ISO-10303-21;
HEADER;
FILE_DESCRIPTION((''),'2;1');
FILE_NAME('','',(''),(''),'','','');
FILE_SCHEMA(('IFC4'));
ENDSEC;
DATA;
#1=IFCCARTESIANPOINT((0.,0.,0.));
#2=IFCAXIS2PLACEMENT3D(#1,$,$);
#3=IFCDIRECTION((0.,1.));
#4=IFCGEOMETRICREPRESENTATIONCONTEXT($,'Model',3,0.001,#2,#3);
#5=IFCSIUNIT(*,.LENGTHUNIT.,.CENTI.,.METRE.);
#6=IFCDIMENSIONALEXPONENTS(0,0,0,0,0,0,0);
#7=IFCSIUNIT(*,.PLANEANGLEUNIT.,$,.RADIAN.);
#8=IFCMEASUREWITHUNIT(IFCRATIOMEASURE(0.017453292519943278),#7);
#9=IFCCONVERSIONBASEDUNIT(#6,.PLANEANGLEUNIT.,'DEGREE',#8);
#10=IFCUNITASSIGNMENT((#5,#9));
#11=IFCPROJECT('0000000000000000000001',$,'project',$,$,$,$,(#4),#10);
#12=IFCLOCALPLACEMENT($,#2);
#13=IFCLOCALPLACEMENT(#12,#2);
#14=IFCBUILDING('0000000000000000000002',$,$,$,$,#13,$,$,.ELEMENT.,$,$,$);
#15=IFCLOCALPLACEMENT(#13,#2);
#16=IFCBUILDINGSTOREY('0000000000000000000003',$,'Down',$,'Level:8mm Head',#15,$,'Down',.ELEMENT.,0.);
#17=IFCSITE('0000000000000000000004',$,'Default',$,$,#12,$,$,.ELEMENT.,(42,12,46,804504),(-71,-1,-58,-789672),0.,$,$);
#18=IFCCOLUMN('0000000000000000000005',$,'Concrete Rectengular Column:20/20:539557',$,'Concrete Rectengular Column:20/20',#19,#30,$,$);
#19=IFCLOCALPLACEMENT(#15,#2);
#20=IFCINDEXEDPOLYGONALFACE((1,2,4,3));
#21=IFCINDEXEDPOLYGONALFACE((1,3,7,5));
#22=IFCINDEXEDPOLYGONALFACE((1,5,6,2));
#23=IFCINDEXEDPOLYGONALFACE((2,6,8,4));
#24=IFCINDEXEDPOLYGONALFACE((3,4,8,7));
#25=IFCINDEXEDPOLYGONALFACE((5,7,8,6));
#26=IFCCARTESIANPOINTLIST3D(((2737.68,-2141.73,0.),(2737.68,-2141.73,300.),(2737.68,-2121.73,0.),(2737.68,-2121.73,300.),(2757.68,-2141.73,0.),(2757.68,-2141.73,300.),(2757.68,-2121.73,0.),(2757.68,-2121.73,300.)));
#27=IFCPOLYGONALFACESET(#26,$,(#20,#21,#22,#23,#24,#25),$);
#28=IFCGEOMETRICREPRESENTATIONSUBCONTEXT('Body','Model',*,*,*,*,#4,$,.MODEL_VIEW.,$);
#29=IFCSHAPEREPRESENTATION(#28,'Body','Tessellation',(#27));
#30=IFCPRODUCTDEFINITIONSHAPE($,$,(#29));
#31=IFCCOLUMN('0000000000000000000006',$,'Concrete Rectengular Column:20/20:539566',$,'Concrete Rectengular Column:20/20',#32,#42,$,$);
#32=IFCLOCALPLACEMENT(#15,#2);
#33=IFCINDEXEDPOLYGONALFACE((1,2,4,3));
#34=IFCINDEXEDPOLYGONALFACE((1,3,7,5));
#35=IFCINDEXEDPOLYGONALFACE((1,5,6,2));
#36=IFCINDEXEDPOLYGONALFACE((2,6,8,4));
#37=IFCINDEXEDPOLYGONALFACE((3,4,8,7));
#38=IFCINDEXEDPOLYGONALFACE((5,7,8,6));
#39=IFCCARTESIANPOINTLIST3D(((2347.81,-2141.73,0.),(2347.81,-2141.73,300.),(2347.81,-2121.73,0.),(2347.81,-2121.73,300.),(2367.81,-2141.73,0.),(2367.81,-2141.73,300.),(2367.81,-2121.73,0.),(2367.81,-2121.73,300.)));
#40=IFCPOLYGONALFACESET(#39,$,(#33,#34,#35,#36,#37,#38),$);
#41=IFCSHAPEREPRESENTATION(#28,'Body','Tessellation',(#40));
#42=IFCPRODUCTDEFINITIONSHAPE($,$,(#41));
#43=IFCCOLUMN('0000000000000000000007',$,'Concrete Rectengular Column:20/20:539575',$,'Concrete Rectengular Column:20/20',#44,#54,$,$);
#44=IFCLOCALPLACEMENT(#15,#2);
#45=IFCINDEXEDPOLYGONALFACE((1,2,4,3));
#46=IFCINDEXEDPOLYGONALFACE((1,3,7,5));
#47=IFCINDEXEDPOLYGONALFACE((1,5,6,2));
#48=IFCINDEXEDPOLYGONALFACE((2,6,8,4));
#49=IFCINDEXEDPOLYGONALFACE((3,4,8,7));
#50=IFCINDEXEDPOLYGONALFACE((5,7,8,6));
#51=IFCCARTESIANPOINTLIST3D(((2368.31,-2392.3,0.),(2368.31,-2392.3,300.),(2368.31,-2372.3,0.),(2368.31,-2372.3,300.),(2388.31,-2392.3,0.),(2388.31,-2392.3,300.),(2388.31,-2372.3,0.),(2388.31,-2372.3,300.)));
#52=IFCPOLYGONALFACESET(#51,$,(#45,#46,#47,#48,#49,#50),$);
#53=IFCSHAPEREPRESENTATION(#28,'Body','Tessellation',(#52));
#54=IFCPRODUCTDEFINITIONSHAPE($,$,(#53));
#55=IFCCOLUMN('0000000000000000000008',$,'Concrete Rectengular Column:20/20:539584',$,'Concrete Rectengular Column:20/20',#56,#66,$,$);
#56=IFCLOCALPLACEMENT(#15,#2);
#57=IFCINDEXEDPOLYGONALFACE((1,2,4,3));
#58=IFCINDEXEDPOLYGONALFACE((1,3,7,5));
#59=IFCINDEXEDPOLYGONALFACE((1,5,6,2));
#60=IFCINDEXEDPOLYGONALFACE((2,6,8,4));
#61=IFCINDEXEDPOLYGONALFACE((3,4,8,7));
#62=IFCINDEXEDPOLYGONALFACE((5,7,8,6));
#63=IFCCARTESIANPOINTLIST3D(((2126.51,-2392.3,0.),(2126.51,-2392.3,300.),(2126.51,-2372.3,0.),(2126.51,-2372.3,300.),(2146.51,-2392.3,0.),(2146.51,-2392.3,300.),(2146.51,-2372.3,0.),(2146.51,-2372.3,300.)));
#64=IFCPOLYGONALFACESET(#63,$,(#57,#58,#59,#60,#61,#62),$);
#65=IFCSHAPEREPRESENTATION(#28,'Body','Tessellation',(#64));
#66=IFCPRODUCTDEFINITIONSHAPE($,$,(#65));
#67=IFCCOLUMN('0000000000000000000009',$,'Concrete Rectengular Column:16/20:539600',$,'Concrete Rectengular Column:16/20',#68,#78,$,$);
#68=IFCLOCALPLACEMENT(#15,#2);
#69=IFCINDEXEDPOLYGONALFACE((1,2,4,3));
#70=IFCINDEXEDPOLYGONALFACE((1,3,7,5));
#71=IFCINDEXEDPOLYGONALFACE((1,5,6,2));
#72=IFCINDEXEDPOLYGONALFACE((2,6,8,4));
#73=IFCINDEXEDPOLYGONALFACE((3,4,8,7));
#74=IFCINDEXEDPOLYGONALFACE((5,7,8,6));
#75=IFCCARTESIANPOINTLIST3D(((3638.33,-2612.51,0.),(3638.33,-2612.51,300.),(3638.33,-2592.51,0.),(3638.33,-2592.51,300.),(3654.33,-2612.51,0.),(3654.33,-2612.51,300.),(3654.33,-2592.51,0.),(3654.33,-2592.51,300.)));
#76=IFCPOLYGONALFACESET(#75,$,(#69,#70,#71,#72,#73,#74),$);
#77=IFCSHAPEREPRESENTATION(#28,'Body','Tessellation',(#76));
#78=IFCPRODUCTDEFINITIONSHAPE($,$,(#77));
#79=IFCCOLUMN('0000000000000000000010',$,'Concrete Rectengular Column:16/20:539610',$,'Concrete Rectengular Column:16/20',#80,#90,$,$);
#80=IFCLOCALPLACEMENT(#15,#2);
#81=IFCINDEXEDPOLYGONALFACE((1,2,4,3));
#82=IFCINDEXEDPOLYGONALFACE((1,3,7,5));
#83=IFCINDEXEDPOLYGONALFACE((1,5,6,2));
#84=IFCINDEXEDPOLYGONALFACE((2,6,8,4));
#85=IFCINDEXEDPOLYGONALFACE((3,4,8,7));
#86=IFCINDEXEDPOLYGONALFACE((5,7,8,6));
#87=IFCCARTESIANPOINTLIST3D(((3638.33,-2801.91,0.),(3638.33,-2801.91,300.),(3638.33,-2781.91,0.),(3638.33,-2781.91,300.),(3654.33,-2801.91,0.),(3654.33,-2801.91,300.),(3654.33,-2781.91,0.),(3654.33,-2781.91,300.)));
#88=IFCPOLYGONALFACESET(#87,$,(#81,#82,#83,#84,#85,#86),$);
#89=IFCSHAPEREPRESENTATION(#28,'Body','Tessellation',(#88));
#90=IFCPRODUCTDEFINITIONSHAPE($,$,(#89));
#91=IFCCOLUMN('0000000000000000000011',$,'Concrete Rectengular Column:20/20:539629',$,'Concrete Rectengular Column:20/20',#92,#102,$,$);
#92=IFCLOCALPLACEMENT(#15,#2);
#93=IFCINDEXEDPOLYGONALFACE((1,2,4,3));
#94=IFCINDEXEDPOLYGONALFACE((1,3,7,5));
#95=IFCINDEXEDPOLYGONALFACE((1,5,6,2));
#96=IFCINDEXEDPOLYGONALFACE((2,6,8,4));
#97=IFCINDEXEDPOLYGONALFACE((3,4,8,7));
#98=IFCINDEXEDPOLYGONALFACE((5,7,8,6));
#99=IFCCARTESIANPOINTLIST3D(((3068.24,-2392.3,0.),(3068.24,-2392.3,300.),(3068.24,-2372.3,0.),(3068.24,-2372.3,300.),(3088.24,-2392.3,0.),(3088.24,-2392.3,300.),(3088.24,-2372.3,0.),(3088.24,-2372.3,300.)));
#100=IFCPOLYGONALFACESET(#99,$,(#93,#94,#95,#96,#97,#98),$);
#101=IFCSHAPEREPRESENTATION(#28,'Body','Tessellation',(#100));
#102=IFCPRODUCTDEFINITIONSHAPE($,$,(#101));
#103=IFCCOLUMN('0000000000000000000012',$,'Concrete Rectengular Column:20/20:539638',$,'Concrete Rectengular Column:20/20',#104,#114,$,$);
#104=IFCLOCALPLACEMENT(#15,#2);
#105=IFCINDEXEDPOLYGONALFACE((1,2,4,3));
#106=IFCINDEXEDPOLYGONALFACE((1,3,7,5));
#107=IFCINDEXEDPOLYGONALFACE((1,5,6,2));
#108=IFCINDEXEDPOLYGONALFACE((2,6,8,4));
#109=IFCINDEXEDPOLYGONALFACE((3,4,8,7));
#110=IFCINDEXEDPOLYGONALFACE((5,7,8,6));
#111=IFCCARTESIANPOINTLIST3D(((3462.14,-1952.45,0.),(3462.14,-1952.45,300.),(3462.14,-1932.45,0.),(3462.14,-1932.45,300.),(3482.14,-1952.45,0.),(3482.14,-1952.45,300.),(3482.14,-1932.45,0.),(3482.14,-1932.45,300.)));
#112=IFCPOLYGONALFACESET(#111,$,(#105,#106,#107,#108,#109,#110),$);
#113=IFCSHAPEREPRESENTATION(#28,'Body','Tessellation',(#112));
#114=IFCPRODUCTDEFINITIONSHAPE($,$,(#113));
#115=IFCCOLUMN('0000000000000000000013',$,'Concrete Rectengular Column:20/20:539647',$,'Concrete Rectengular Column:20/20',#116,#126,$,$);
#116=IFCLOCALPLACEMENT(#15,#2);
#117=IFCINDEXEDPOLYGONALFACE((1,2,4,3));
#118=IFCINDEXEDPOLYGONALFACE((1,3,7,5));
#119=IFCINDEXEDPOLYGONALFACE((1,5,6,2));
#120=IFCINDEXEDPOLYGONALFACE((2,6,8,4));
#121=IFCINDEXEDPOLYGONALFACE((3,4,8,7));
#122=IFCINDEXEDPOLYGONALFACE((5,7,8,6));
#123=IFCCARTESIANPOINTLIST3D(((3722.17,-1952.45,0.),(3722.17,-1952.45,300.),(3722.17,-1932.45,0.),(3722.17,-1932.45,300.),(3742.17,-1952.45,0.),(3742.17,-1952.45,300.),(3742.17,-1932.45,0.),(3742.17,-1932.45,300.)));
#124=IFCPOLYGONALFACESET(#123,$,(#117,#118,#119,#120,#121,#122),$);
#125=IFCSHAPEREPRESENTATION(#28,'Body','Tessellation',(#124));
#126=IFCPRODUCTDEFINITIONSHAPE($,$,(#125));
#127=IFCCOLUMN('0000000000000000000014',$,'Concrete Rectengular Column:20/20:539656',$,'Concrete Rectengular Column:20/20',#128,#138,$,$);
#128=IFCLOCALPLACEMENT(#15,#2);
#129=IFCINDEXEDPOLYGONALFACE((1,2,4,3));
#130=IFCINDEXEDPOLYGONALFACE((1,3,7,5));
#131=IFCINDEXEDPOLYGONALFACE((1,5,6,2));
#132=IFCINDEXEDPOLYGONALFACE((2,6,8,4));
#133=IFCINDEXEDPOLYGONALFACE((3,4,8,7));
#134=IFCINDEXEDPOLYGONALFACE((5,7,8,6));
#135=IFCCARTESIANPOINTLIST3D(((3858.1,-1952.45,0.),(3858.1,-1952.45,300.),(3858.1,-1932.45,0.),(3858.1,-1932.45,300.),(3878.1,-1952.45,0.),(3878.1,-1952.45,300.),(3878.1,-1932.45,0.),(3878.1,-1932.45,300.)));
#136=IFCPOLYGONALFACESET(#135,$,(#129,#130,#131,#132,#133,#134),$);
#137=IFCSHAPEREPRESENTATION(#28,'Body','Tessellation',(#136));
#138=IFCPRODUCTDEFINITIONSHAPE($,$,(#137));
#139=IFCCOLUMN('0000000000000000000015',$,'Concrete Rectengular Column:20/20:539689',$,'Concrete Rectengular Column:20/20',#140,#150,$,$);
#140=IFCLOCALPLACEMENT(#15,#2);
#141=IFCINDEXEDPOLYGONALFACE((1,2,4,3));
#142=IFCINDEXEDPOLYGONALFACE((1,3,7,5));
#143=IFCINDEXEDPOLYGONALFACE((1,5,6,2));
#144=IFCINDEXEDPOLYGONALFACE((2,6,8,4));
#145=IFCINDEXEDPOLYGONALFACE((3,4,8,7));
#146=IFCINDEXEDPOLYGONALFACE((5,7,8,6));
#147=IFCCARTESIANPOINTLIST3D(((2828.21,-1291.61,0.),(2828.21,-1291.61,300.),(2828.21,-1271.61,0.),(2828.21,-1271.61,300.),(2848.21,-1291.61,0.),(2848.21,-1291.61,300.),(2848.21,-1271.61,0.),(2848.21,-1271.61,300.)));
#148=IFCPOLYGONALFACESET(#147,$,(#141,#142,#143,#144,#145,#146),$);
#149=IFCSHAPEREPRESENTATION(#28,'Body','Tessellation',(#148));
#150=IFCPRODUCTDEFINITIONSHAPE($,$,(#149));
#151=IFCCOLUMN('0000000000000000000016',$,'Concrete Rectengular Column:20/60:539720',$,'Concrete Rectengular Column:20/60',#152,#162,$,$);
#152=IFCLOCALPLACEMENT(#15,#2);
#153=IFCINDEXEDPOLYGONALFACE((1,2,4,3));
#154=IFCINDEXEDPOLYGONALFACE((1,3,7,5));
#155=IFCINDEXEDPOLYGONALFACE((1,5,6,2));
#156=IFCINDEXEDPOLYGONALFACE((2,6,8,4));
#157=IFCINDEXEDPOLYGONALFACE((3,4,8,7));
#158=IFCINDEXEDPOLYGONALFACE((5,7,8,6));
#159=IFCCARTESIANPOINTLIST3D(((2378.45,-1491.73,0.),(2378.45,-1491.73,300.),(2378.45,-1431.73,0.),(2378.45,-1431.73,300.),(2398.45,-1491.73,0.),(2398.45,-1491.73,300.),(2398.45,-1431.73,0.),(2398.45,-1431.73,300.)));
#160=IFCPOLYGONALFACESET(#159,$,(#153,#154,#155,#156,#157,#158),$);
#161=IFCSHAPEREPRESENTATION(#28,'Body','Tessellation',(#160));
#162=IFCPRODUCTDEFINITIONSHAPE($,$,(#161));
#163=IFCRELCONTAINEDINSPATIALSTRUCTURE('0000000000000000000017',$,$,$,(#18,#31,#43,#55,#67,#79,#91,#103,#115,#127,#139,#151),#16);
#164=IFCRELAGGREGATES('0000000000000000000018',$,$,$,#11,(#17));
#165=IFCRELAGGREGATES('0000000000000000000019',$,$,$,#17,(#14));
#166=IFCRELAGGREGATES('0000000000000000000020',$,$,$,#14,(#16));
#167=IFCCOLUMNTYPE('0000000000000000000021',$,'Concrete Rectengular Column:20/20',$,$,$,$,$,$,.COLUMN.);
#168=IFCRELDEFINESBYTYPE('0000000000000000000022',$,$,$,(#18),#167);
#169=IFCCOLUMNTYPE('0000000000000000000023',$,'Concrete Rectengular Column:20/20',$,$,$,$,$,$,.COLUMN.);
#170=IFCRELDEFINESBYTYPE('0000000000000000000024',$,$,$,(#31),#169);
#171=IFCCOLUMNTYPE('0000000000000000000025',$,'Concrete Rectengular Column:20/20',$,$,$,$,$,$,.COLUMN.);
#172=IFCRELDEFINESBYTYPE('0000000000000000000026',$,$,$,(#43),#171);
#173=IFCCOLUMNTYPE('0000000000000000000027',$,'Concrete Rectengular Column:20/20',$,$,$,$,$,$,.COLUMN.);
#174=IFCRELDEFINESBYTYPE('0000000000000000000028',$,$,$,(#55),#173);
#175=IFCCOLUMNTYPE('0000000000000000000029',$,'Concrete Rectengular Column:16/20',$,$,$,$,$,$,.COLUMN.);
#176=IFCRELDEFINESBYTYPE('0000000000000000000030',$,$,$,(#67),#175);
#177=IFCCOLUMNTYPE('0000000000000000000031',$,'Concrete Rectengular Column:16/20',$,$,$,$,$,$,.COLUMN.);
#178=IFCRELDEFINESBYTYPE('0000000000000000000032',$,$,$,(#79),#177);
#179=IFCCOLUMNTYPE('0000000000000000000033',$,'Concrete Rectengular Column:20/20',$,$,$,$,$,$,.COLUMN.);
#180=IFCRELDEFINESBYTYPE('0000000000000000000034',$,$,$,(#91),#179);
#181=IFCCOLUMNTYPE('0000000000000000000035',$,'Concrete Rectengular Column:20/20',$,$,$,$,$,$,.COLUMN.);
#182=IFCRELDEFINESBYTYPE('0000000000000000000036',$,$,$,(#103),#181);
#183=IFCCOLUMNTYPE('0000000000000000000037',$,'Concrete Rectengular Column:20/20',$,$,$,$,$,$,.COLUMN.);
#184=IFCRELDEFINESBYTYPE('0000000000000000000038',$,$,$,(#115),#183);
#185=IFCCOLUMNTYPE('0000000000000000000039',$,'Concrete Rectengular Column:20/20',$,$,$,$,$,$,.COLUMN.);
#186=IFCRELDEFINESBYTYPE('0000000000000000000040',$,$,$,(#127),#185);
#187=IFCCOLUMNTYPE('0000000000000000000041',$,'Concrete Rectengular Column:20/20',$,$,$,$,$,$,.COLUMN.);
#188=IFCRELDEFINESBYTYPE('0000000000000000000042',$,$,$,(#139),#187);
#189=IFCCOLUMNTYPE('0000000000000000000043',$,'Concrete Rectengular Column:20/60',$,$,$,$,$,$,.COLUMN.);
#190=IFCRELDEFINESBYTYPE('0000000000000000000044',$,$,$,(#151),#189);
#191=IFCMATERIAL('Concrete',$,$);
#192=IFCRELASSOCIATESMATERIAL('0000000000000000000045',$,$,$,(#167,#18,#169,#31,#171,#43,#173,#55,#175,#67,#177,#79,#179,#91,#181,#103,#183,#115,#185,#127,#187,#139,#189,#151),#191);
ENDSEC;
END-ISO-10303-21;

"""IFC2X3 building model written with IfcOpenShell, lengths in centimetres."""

from ifc_helpers import new_model, entity, si_unit, converted_unit, direction, frame, frame_2d, origin, origin_2d_with_axis, place, context, subcontext, project, spatial, rectangle, extrude, source, transform, mapped, material, type_object, type_shapes, element, save


model = new_model("IFC2X3")

# Units and contexts
model_context = context("Model", 3, precision=0.001, world=origin(), true_north=direction((0.0, 1.0)))
body_context = subcontext(model_context, "Body", "Model", "MODEL_VIEW")
ifc_project = project(units=[si_unit("LENGTHUNIT", "METRE", prefix="CENTI"), converted_unit("PLANEANGLEUNIT", "DEGREE", entity("IfcRatioMeasure", 0.017453292519943278), si_unit("PLANEANGLEUNIT", "RADIAN"), dimensions=[0, 0, 0, 0, 0, 0, 0])], contexts=[model_context])

# Site, building, storey
site_placement = place(None, origin())
site = spatial("IfcSite", under=ifc_project, at=site_placement, Name="Default", CompositionType="ELEMENT", RefLatitude=(42, 12, 46, 804504), RefLongitude=(-71, -1, -58, -789672), RefElevation=0.0)
building_placement = place(site_placement, origin())
building = spatial("IfcBuilding", under=site, at=building_placement, CompositionType="ELEMENT")
storey_placement = place(building_placement, origin())
storey = spatial("IfcBuildingStorey", under=building, at=storey_placement, Name="Down", ObjectType="Level:8mm Head", LongName="Down", CompositionType="ELEMENT", Elevation=0.0)

# Columns
ifc_material = material(Name="Concrete")
column_type_1 = type_object("IfcColumnType", Name="Concrete Rectengular Column:20/20", PredefinedType="COLUMN", material=ifc_material)
shared_shape_1 = source(origin(), body_context, "Body", "SweptSolid", [
    extrude(rectangle(XDim=20.0, YDim=20.0, at=origin_2d_with_axis()), frame((2747.68, -2131.73, 0.0), z_axis=(0.0, 0.0, 1.0), x_axis=(0.0, -1.0, 0.0)), (0.0, 0.0, 1.0), 300.0),
])
type_shapes(column_type_1, [shared_shape_1])
column_1_placement = place(storey_placement, origin())
element("IfcColumn", 1, at=column_1_placement, inside=storey, type_object=column_type_1, material=ifc_material, Name="Concrete Rectengular Column:20/20:539557", ObjectType="Concrete Rectengular Column:20/20", context=body_context, shape_type="MappedRepresentation", body=[
    mapped(shared_shape_1, transform((0.0, 0.0, 0.0), scale=1.0)),
])
column_type_2 = type_object("IfcColumnType", Name="Concrete Rectengular Column:20/20", PredefinedType="COLUMN", material=ifc_material)
shared_shape_2 = source(origin(), body_context, "Body", "SweptSolid", [
    extrude(rectangle(XDim=20.0, YDim=20.0, at=origin_2d_with_axis()), frame((2357.81, -2131.73, 0.0), z_axis=(0.0, 0.0, 1.0), x_axis=(0.0, -1.0, 0.0)), (0.0, 0.0, 1.0), 300.0),
])
type_shapes(column_type_2, [shared_shape_2])
column_2_placement = place(storey_placement, origin())
element("IfcColumn", 2, at=column_2_placement, inside=storey, type_object=column_type_2, material=ifc_material, Name="Concrete Rectengular Column:20/20:539566", ObjectType="Concrete Rectengular Column:20/20", context=body_context, shape_type="MappedRepresentation", body=[
    mapped(shared_shape_2, transform((0.0, 0.0, 0.0), scale=1.0)),
])
column_type_3 = type_object("IfcColumnType", Name="Concrete Rectengular Column:20/20", PredefinedType="COLUMN", material=ifc_material)
shared_shape_3 = source(origin(), body_context, "Body", "SweptSolid", [
    extrude(rectangle(XDim=20.0, YDim=20.0, at=origin_2d_with_axis()), frame((2378.31, -2382.3, 0.0), z_axis=(0.0, 0.0, 1.0), x_axis=(0.0, -1.0, 0.0)), (0.0, 0.0, 1.0), 300.0),
])
type_shapes(column_type_3, [shared_shape_3])
column_3_placement = place(storey_placement, origin())
element("IfcColumn", 3, at=column_3_placement, inside=storey, type_object=column_type_3, material=ifc_material, Name="Concrete Rectengular Column:20/20:539575", ObjectType="Concrete Rectengular Column:20/20", context=body_context, shape_type="MappedRepresentation", body=[
    mapped(shared_shape_3, transform((0.0, 0.0, 0.0), scale=1.0)),
])
column_type_4 = type_object("IfcColumnType", Name="Concrete Rectengular Column:20/20", PredefinedType="COLUMN", material=ifc_material)
shared_shape_4 = source(origin(), body_context, "Body", "SweptSolid", [
    extrude(rectangle(XDim=20.0, YDim=20.0, at=origin_2d_with_axis()), frame((2136.51, -2382.3, 0.0), z_axis=(0.0, 0.0, 1.0), x_axis=(0.0, -1.0, 0.0)), (0.0, 0.0, 1.0), 300.0),
])
type_shapes(column_type_4, [shared_shape_4])
column_4_placement = place(storey_placement, origin())
element("IfcColumn", 4, at=column_4_placement, inside=storey, type_object=column_type_4, material=ifc_material, Name="Concrete Rectengular Column:20/20:539584", ObjectType="Concrete Rectengular Column:20/20", context=body_context, shape_type="MappedRepresentation", body=[
    mapped(shared_shape_4, transform((0.0, 0.0, 0.0), scale=1.0)),
])
column_type_5 = type_object("IfcColumnType", Name="Concrete Rectengular Column:16/20", PredefinedType="COLUMN", material=ifc_material)
shared_shape_5 = source(origin(), body_context, "Body", "SweptSolid", [
    extrude(rectangle(XDim=20.0, YDim=16.0, at=origin_2d_with_axis()), frame((3646.33, -2602.51, 0.0), z_axis=(0.0, 0.0, 1.0), x_axis=(0.0, -1.0, 0.0)), (0.0, 0.0, 1.0), 300.0),
])
type_shapes(column_type_5, [shared_shape_5])
column_5_placement = place(storey_placement, origin())
element("IfcColumn", 5, at=column_5_placement, inside=storey, type_object=column_type_5, material=ifc_material, Name="Concrete Rectengular Column:16/20:539600", ObjectType="Concrete Rectengular Column:16/20", context=body_context, shape_type="MappedRepresentation", body=[
    mapped(shared_shape_5, transform((0.0, 0.0, 0.0), scale=1.0)),
])
column_type_6 = type_object("IfcColumnType", Name="Concrete Rectengular Column:16/20", PredefinedType="COLUMN", material=ifc_material)
shared_shape_6 = source(origin(), body_context, "Body", "SweptSolid", [
    extrude(rectangle(XDim=20.0, YDim=16.0, at=origin_2d_with_axis()), frame((3646.33, -2791.91, 0.0), z_axis=(0.0, 0.0, 1.0), x_axis=(0.0, -1.0, 0.0)), (0.0, 0.0, 1.0), 300.0),
])
type_shapes(column_type_6, [shared_shape_6])
column_6_placement = place(storey_placement, origin())
element("IfcColumn", 6, at=column_6_placement, inside=storey, type_object=column_type_6, material=ifc_material, Name="Concrete Rectengular Column:16/20:539610", ObjectType="Concrete Rectengular Column:16/20", context=body_context, shape_type="MappedRepresentation", body=[
    mapped(shared_shape_6, transform((0.0, 0.0, 0.0), scale=1.0)),
])
column_type_7 = type_object("IfcColumnType", Name="Concrete Rectengular Column:20/20", PredefinedType="COLUMN", material=ifc_material)
shared_shape_7 = source(origin(), body_context, "Body", "SweptSolid", [
    extrude(rectangle(XDim=20.0, YDim=20.0, at=origin_2d_with_axis()), frame((3078.24, -2382.3, 0.0), z_axis=(0.0, 0.0, 1.0), x_axis=(0.0, -1.0, 0.0)), (0.0, 0.0, 1.0), 300.0),
])
type_shapes(column_type_7, [shared_shape_7])
column_7_placement = place(storey_placement, origin())
element("IfcColumn", 7, at=column_7_placement, inside=storey, type_object=column_type_7, material=ifc_material, Name="Concrete Rectengular Column:20/20:539629", ObjectType="Concrete Rectengular Column:20/20", context=body_context, shape_type="MappedRepresentation", body=[
    mapped(shared_shape_7, transform((0.0, 0.0, 0.0), scale=1.0)),
])
column_type_8 = type_object("IfcColumnType", Name="Concrete Rectengular Column:20/20", PredefinedType="COLUMN", material=ifc_material)
shared_shape_8 = source(origin(), body_context, "Body", "SweptSolid", [
    extrude(rectangle(XDim=20.0, YDim=20.0, at=frame_2d((0.0, 0.0), x_axis=(1.0, 0.0))), frame((3472.14, -1942.45, 0.0), z_axis=(0.0, 0.0, 1.0), x_axis=(0.0, -1.0, 0.0)), (0.0, 0.0, 1.0), 300.0),
])
type_shapes(column_type_8, [shared_shape_8])
column_8_placement = place(storey_placement, origin())
element("IfcColumn", 8, at=column_8_placement, inside=storey, type_object=column_type_8, material=ifc_material, Name="Concrete Rectengular Column:20/20:539638", ObjectType="Concrete Rectengular Column:20/20", context=body_context, shape_type="MappedRepresentation", body=[
    mapped(shared_shape_8, transform((0.0, 0.0, 0.0), scale=1.0)),
])
column_type_9 = type_object("IfcColumnType", Name="Concrete Rectengular Column:20/20", PredefinedType="COLUMN", material=ifc_material)
shared_shape_9 = source(origin(), body_context, "Body", "SweptSolid", [
    extrude(rectangle(XDim=20.0, YDim=20.0, at=frame_2d((0.0, 0.0), x_axis=(1.0, 0.0))), frame((3732.17, -1942.45, 0.0), z_axis=(0.0, 0.0, 1.0), x_axis=(0.0, -1.0, 0.0)), (0.0, 0.0, 1.0), 300.0),
])
type_shapes(column_type_9, [shared_shape_9])
column_9_placement = place(storey_placement, origin())
element("IfcColumn", 9, at=column_9_placement, inside=storey, type_object=column_type_9, material=ifc_material, Name="Concrete Rectengular Column:20/20:539647", ObjectType="Concrete Rectengular Column:20/20", context=body_context, shape_type="MappedRepresentation", body=[
    mapped(shared_shape_9, transform((0.0, 0.0, 0.0), scale=1.0)),
])
column_type_10 = type_object("IfcColumnType", Name="Concrete Rectengular Column:20/20", PredefinedType="COLUMN", material=ifc_material)
shared_shape_10 = source(origin(), body_context, "Body", "SweptSolid", [
    extrude(rectangle(XDim=20.0, YDim=20.0, at=frame_2d((0.0, 0.0), x_axis=(1.0, 0.0))), frame((3868.1, -1942.45, 0.0), z_axis=(0.0, 0.0, 1.0), x_axis=(0.0, -1.0, 0.0)), (0.0, 0.0, 1.0), 300.0),
])
type_shapes(column_type_10, [shared_shape_10])
column_10_placement = place(storey_placement, origin())
element("IfcColumn", 10, at=column_10_placement, inside=storey, type_object=column_type_10, material=ifc_material, Name="Concrete Rectengular Column:20/20:539656", ObjectType="Concrete Rectengular Column:20/20", context=body_context, shape_type="MappedRepresentation", body=[
    mapped(shared_shape_10, transform((0.0, 0.0, 0.0), scale=1.0)),
])
column_type_11 = type_object("IfcColumnType", Name="Concrete Rectengular Column:20/20", PredefinedType="COLUMN", material=ifc_material)
shared_shape_11 = source(origin(), body_context, "Body", "SweptSolid", [
    extrude(rectangle(XDim=20.0, YDim=20.0, at=frame_2d((0.0, 0.0), x_axis=(1.0, 0.0))), frame((2838.21, -1281.61, 0.0), z_axis=(0.0, 0.0, 1.0), x_axis=(0.0, -1.0, 0.0)), (0.0, 0.0, 1.0), 300.0),
])
type_shapes(column_type_11, [shared_shape_11])
column_11_placement = place(storey_placement, origin())
element("IfcColumn", 11, at=column_11_placement, inside=storey, type_object=column_type_11, material=ifc_material, Name="Concrete Rectengular Column:20/20:539689", ObjectType="Concrete Rectengular Column:20/20", context=body_context, shape_type="MappedRepresentation", body=[
    mapped(shared_shape_11, transform((0.0, 0.0, 0.0), scale=1.0)),
])
column_type_12 = type_object("IfcColumnType", Name="Concrete Rectengular Column:20/60", PredefinedType="COLUMN", material=ifc_material)
shared_shape_12 = source(origin(), body_context, "Body", "SweptSolid", [
    extrude(rectangle(XDim=60.0, YDim=20.0, at=frame_2d((0.0, 0.0), x_axis=(1.0, 0.0))), frame((2388.45, -1461.73, 0.0), z_axis=(0.0, 0.0, 1.0), x_axis=(0.0, -1.0, 0.0)), (0.0, 0.0, 1.0), 300.0),
])
type_shapes(column_type_12, [shared_shape_12])
column_12_placement = place(storey_placement, origin())
element("IfcColumn", 12, at=column_12_placement, inside=storey, type_object=column_type_12, material=ifc_material, Name="Concrete Rectengular Column:20/60:539720", ObjectType="Concrete Rectengular Column:20/60", context=body_context, shape_type="MappedRepresentation", body=[
    mapped(shared_shape_12, transform((0.0, 0.0, 0.0), scale=1.0)),
])

save(model, "model.ifc")
